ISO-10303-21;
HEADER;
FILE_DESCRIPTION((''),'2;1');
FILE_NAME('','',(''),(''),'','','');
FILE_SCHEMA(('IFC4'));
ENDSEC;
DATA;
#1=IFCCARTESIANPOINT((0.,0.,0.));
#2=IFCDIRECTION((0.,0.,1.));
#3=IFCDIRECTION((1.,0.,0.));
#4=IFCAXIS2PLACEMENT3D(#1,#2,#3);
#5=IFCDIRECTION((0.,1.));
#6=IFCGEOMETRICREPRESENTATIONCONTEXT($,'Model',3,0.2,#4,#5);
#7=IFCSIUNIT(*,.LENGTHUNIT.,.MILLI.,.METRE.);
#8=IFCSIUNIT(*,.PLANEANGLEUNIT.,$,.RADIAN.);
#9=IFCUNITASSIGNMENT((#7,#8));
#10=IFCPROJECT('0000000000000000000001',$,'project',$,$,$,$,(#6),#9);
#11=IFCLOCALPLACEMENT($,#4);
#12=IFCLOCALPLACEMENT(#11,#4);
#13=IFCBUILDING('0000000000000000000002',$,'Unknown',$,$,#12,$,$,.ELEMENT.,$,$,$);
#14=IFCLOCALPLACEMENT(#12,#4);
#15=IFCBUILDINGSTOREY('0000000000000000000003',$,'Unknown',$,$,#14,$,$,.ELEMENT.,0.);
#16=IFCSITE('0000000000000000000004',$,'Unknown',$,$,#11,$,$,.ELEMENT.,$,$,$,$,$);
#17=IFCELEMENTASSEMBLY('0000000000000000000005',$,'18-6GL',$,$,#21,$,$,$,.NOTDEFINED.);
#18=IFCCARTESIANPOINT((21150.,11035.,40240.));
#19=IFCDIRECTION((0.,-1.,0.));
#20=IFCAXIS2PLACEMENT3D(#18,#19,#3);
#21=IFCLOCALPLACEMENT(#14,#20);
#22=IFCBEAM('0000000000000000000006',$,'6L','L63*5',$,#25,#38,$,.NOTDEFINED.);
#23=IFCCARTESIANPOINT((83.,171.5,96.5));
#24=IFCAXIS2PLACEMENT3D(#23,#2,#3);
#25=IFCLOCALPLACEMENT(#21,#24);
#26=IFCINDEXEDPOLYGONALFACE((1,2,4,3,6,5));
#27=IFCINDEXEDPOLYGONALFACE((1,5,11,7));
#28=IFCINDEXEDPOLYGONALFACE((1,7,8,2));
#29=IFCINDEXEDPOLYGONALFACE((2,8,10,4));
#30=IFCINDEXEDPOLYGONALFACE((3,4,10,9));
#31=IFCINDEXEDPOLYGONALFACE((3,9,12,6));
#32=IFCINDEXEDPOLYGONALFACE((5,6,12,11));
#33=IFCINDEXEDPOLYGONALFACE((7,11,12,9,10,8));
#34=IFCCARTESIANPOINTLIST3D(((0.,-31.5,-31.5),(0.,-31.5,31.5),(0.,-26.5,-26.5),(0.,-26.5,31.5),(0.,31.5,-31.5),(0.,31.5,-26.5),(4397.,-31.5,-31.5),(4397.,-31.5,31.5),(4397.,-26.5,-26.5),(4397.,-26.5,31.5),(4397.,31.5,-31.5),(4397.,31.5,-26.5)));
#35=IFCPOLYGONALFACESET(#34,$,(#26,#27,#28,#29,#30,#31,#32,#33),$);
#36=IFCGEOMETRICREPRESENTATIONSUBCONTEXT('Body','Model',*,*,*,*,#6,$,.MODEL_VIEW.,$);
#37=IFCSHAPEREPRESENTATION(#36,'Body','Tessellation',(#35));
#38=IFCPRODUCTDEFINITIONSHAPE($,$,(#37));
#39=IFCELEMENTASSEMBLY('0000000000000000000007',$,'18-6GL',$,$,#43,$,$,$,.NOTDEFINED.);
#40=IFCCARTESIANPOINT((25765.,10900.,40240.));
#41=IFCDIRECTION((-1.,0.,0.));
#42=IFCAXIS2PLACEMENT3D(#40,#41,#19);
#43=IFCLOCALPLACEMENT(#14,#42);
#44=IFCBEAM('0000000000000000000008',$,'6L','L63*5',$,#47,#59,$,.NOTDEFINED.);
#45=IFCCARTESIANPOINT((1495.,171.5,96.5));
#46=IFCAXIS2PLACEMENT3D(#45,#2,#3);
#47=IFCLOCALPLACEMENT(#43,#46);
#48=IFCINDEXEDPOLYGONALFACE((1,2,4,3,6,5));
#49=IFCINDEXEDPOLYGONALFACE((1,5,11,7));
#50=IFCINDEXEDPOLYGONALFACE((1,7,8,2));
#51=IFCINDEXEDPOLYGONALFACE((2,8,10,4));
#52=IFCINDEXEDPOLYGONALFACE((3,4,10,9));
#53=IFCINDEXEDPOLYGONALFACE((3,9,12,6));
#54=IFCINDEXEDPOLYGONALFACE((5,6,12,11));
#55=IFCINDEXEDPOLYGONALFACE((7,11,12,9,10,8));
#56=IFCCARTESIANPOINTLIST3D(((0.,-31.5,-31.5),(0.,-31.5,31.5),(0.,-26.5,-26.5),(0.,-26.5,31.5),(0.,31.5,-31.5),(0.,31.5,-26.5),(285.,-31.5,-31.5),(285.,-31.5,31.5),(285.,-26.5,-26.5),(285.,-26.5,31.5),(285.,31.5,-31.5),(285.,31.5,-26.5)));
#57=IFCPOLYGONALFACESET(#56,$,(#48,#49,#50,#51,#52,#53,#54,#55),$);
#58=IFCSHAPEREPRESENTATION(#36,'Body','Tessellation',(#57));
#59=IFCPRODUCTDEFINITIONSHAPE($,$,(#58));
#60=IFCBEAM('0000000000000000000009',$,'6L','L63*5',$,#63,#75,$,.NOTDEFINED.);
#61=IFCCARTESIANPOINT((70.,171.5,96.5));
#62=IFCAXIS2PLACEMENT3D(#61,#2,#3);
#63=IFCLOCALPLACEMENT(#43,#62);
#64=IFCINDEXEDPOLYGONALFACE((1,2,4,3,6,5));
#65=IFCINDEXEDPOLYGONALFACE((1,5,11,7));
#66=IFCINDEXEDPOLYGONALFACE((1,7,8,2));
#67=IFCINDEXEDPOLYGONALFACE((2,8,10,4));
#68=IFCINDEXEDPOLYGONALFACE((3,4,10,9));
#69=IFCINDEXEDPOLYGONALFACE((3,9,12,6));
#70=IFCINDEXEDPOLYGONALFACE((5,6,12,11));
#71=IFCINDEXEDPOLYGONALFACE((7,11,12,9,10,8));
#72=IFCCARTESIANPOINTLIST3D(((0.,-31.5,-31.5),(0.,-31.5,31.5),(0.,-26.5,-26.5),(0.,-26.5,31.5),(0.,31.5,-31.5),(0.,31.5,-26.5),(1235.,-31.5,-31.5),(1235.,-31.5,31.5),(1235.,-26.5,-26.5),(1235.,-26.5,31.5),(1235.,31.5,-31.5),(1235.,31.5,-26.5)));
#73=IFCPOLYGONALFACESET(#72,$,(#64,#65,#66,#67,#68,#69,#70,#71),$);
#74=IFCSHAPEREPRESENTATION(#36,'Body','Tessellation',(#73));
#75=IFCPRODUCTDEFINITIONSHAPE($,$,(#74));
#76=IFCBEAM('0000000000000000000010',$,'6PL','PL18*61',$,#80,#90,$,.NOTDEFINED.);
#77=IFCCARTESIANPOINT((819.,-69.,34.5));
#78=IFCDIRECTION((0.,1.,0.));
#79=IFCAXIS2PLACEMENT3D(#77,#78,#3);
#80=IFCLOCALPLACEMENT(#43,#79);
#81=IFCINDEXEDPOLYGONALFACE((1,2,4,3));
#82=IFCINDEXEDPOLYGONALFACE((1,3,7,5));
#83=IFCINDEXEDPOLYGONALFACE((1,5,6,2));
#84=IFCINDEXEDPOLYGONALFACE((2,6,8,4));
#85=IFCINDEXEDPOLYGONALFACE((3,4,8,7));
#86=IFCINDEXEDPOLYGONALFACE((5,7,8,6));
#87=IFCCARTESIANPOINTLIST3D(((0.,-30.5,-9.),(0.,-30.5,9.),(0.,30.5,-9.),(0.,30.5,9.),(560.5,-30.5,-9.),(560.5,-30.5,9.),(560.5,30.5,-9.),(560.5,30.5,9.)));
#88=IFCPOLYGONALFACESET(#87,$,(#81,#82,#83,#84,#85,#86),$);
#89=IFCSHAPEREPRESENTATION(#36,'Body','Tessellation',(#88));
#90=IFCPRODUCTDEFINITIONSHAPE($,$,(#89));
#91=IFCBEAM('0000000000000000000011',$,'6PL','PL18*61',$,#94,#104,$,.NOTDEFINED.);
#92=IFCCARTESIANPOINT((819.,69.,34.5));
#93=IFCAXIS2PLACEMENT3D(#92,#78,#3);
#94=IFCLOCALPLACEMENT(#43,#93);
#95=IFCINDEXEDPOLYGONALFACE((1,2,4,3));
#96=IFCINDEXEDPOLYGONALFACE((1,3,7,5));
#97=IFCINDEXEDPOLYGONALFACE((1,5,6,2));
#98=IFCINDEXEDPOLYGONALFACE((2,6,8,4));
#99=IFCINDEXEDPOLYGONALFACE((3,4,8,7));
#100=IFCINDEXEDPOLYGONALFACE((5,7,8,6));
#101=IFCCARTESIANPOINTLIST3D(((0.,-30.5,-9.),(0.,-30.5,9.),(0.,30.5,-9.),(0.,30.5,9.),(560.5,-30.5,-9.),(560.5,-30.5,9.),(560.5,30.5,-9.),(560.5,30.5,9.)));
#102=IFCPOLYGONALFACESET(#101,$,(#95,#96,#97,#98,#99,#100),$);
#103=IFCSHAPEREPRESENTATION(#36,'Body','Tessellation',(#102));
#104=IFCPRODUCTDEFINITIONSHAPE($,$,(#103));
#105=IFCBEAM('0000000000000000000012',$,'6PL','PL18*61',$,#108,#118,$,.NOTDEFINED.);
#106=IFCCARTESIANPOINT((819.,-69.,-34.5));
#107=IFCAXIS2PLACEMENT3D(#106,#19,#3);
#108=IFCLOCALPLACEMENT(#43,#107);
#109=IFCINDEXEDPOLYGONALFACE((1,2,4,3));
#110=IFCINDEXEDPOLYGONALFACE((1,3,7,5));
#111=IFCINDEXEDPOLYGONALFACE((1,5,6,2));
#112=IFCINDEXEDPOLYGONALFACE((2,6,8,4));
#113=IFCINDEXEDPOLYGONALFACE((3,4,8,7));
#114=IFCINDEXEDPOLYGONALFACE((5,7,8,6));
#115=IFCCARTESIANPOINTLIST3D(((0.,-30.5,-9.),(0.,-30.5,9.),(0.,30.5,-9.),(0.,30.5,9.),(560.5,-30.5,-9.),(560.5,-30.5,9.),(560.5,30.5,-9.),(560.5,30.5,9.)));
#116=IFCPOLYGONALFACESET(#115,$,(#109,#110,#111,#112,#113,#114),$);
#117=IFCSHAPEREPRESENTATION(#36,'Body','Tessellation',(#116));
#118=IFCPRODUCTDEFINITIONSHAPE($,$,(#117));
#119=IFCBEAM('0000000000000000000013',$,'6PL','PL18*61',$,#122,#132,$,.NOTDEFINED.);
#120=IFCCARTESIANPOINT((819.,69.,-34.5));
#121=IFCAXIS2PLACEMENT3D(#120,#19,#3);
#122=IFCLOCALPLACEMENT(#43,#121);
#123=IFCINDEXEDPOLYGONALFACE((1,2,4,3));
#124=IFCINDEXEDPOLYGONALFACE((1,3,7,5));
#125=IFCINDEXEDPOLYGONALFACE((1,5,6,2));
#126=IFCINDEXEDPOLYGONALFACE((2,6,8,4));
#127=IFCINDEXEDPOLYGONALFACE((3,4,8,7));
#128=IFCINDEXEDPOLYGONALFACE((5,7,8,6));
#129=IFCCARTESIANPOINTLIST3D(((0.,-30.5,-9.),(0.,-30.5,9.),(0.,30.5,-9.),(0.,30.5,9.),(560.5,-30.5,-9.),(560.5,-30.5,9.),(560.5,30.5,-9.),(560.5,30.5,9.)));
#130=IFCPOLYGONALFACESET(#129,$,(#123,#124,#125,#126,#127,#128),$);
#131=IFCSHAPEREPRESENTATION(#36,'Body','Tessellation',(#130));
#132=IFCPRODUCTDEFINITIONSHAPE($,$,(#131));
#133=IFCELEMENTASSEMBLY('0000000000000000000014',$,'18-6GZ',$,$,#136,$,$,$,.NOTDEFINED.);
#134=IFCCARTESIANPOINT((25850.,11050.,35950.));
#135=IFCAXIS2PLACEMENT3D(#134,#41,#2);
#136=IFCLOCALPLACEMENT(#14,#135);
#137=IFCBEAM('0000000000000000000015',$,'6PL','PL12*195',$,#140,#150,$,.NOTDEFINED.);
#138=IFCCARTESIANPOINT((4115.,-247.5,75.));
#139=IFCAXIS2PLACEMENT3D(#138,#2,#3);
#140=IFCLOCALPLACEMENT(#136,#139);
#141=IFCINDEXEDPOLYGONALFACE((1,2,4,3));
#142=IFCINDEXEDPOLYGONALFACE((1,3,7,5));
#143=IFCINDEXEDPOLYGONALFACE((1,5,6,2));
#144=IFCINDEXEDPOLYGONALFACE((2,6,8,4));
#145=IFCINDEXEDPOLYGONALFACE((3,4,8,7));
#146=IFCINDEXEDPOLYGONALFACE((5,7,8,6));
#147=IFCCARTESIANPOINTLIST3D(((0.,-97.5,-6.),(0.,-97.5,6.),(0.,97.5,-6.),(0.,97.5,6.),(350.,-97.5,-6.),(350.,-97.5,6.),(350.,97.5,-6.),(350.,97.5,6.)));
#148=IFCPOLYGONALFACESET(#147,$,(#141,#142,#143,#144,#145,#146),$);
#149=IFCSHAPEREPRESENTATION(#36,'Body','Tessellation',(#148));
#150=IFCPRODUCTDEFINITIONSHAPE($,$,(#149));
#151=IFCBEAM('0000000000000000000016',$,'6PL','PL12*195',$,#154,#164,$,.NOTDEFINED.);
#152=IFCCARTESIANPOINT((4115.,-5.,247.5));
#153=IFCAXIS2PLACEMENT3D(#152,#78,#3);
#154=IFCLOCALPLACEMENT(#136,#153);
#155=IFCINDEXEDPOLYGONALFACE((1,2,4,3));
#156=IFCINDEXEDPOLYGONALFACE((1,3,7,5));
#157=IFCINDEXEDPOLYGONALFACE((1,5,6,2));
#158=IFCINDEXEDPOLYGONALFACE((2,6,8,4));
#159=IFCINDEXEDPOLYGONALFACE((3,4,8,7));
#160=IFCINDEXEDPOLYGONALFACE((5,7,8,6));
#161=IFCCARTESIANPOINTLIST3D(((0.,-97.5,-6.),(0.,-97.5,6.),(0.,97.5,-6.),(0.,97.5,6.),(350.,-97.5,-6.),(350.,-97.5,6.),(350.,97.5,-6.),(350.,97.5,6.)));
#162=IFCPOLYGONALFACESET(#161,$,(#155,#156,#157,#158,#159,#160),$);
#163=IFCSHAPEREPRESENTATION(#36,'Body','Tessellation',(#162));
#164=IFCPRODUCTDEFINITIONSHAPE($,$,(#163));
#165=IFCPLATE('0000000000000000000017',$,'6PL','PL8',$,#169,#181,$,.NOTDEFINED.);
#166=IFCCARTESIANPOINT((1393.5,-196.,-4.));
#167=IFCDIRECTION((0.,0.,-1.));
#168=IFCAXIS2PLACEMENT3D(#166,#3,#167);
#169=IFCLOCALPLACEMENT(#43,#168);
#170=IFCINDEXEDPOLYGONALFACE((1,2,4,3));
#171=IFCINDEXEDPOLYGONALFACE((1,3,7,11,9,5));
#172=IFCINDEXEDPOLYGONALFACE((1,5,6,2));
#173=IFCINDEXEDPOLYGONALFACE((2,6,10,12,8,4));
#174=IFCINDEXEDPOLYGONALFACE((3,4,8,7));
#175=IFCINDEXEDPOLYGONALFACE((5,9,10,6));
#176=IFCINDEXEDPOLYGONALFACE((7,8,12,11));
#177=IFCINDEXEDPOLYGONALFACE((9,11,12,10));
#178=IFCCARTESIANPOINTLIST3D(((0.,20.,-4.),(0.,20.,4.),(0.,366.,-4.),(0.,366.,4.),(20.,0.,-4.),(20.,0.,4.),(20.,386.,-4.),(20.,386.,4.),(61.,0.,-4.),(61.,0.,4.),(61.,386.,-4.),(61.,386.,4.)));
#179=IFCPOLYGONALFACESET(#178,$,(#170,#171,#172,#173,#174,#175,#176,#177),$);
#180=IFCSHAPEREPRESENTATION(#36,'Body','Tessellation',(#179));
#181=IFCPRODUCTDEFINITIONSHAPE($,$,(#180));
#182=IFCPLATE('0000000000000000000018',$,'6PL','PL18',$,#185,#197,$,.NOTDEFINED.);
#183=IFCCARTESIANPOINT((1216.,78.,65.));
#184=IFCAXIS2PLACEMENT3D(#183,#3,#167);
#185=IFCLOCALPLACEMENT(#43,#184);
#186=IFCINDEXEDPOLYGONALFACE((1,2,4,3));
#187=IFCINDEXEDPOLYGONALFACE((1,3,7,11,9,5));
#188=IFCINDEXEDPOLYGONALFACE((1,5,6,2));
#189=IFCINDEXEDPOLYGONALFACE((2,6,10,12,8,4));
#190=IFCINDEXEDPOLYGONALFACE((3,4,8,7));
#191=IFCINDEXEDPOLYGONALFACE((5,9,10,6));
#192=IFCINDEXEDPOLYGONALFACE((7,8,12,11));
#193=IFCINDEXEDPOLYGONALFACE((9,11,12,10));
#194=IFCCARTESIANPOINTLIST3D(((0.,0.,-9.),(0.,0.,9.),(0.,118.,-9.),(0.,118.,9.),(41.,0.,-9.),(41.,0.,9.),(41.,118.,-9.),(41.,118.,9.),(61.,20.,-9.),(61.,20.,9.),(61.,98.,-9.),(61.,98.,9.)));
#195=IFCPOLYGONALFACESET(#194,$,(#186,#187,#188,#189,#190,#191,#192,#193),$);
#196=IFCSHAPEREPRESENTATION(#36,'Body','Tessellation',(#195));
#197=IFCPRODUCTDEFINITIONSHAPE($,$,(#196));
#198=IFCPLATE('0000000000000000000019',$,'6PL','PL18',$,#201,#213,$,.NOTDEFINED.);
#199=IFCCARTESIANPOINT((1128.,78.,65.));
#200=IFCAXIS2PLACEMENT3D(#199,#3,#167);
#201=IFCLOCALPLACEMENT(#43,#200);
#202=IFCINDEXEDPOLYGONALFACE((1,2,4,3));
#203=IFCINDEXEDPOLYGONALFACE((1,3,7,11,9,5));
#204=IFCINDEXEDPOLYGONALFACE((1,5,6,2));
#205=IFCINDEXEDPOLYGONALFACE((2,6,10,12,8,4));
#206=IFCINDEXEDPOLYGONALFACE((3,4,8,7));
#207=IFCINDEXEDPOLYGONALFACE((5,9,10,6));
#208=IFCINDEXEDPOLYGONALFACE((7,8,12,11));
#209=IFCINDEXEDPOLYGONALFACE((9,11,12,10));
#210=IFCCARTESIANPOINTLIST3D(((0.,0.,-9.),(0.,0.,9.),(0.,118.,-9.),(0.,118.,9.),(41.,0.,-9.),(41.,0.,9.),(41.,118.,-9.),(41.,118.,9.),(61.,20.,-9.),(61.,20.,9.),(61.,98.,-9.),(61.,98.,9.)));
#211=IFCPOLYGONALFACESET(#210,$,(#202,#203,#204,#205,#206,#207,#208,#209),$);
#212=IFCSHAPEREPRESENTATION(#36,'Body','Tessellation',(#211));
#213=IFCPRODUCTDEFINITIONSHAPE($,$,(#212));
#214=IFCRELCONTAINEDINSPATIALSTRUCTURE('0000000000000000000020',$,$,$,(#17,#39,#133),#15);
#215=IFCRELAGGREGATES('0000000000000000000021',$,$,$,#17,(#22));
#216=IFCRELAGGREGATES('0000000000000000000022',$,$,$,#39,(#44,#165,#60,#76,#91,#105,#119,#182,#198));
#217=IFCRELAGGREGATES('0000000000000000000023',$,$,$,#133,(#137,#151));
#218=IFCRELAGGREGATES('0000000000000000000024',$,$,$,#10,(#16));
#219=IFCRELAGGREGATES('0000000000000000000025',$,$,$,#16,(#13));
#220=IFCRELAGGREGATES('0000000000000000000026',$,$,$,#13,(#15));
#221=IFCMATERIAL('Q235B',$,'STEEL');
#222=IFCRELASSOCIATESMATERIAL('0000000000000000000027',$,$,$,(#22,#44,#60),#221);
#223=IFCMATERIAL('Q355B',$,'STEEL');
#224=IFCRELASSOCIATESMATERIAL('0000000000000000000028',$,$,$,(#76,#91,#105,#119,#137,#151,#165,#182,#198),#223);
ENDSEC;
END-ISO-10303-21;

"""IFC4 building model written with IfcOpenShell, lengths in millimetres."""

from ifc_helpers import new_model, si_unit, direction, frame, origin_with_axes, place, context, subcontext, project, spatial, line, indexed_curve, outline, extrude, material, element, aggregate, save


model = new_model("IFC4")

# Units and contexts
model_context = context("Model", 3, precision=0.2, world=origin_with_axes(), true_north=direction((0.0, 1.0)))
body_context = subcontext(model_context, "Body", "Model", "MODEL_VIEW")
ifc_project = project(units=[si_unit("LENGTHUNIT", "METRE", prefix="MILLI"), si_unit("PLANEANGLEUNIT", "RADIAN")], contexts=[model_context])

# Site, building, storey
site_placement = place(None, origin_with_axes())
site = spatial("IfcSite", under=ifc_project, at=site_placement, Name="Unknown", CompositionType="ELEMENT")
building_placement = place(site_placement, origin_with_axes())
building = spatial("IfcBuilding", under=site, at=building_placement, Name="Unknown", CompositionType="ELEMENT")
storey_placement = place(building_placement, origin_with_axes())
storey = spatial("IfcBuildingStorey", under=building, at=storey_placement, Name="Unknown", CompositionType="ELEMENT", Elevation=0.0)

# Element assembly, beam
assembly_1_placement = place(storey_placement, frame((21150.0, 11035.0, 40240.0), z_axis=(0.0, -1.0, 0.0), x_axis=(1.0, 0.0, 0.0)))
assembly_1 = element("IfcElementAssembly", 1, at=assembly_1_placement, inside=storey, Name="18-6GL", PredefinedType="NOTDEFINED")
ifc_material_1 = material(Name="Q235B", Category="STEEL")
beam_1_placement = place(assembly_1_placement, frame((83.0, 171.5, 96.5), z_axis=(0.0, 0.0, 1.0), x_axis=(1.0, 0.0, 0.0)))
beam_1 = element("IfcBeam", 2, at=beam_1_placement, material=ifc_material_1, Name="6L", Description="L63*5", PredefinedType="NOTDEFINED", context=body_context, shape_type="SolidModel", body=[
    extrude(outline(indexed_curve([(-31.5, -31.5), (31.5, -31.5), (31.5, -26.5), (-26.5, -26.5), (-26.5, 31.5), (-31.5, 31.5)], segments=[line(1, 2, 3, 4, 5, 6, 1)])), frame((0.0, 0.0, 0.0), z_axis=(-1.0, 0.0, 0.0), x_axis=(0.0, 0.0, 1.0)), (0.0, 0.0, -1.0), 4397.0),
])

# Element assembly, beams
assembly_2_placement = place(storey_placement, frame((25765.0, 10900.0, 40240.0), z_axis=(-1.0, 0.0, 0.0), x_axis=(0.0, -1.0, 0.0)))
assembly_2 = element("IfcElementAssembly", 3, at=assembly_2_placement, inside=storey, Name="18-6GL", PredefinedType="NOTDEFINED")
beam_2_placement = place(assembly_2_placement, frame((1495.0, 171.5, 96.5), z_axis=(0.0, 0.0, 1.0), x_axis=(1.0, 0.0, 0.0)))
beam_2 = element("IfcBeam", 4, at=beam_2_placement, material=ifc_material_1, Name="6L", Description="L63*5", PredefinedType="NOTDEFINED", context=body_context, shape_type="SolidModel", body=[
    extrude(outline(indexed_curve([(-31.5, -31.5), (31.5, -31.5), (31.5, -26.5), (-26.5, -26.5), (-26.5, 31.5), (-31.5, 31.5)], segments=[line(1, 2, 3, 4, 5, 6, 1)])), frame((0.0, 0.0, 0.0), z_axis=(-1.0, 0.0, 0.0), x_axis=(0.0, 0.0, 1.0)), (0.0, 0.0, -1.0), 285.0),
])
beam_3_placement = place(assembly_2_placement, frame((70.0, 171.5, 96.5), z_axis=(0.0, 0.0, 1.0), x_axis=(1.0, 0.0, 0.0)))
beam_3 = element("IfcBeam", 5, at=beam_3_placement, material=ifc_material_1, Name="6L", Description="L63*5", PredefinedType="NOTDEFINED", context=body_context, shape_type="SolidModel", body=[
    extrude(outline(indexed_curve([(-31.5, -31.5), (31.5, -31.5), (31.5, -26.5), (-26.5, -26.5), (-26.5, 31.5), (-31.5, 31.5)], segments=[line(1, 2, 3, 4, 5, 6, 1)])), frame((0.0, 0.0, 0.0), z_axis=(-1.0, 0.0, 0.0), x_axis=(0.0, 0.0, 1.0)), (0.0, 0.0, -1.0), 1235.0),
])
ifc_material_2 = material(Name="Q355B", Category="STEEL")
beam_4_placement = place(assembly_2_placement, frame((819.0, -69.0, 34.5), z_axis=(0.0, 1.0, 0.0), x_axis=(1.0, 0.0, 0.0)))
beam_4 = element("IfcBeam", 6, at=beam_4_placement, material=ifc_material_2, Name="6PL", Description="PL18*61", PredefinedType="NOTDEFINED", context=body_context, shape_type="SolidModel", body=[
    extrude(outline(indexed_curve([(-9.0, -30.5), (9.0, -30.5), (9.0, 30.5), (-9.0, 30.5)], segments=[line(1, 2, 3, 4, 1)])), frame((0.0, 0.0, 0.0), z_axis=(-1.0, 0.0, 0.0), x_axis=(0.0, 0.0, 1.0)), (0.0, 0.0, -1.0), 560.5),
])
beam_5_placement = place(assembly_2_placement, frame((819.0, 69.0, 34.5), z_axis=(0.0, 1.0, 0.0), x_axis=(1.0, 0.0, 0.0)))
beam_5 = element("IfcBeam", 7, at=beam_5_placement, material=ifc_material_2, Name="6PL", Description="PL18*61", PredefinedType="NOTDEFINED", context=body_context, shape_type="SolidModel", body=[
    extrude(outline(indexed_curve([(-9.0, -30.5), (9.0, -30.5), (9.0, 30.5), (-9.0, 30.5)], segments=[line(1, 2, 3, 4, 1)])), frame((0.0, 0.0, 0.0), z_axis=(-1.0, 0.0, 0.0), x_axis=(0.0, 0.0, 1.0)), (0.0, 0.0, -1.0), 560.5),
])
beam_6_placement = place(assembly_2_placement, frame((819.0, -69.0, -34.5), z_axis=(0.0, -1.0, 0.0), x_axis=(1.0, 0.0, 0.0)))
beam_6 = element("IfcBeam", 8, at=beam_6_placement, material=ifc_material_2, Name="6PL", Description="PL18*61", PredefinedType="NOTDEFINED", context=body_context, shape_type="SolidModel", body=[
    extrude(outline(indexed_curve([(-9.0, -30.5), (9.0, -30.5), (9.0, 30.5), (-9.0, 30.5)], segments=[line(1, 2, 3, 4, 1)])), frame((0.0, 0.0, 0.0), z_axis=(-1.0, 0.0, 0.0), x_axis=(0.0, 0.0, 1.0)), (0.0, 0.0, -1.0), 560.5),
])
beam_7_placement = place(assembly_2_placement, frame((819.0, 69.0, -34.5), z_axis=(0.0, -1.0, 0.0), x_axis=(1.0, 0.0, 0.0)))
beam_7 = element("IfcBeam", 9, at=beam_7_placement, material=ifc_material_2, Name="6PL", Description="PL18*61", PredefinedType="NOTDEFINED", context=body_context, shape_type="SolidModel", body=[
    extrude(outline(indexed_curve([(-9.0, -30.5), (9.0, -30.5), (9.0, 30.5), (-9.0, 30.5)], segments=[line(1, 2, 3, 4, 1)])), frame((0.0, 0.0, 0.0), z_axis=(-1.0, 0.0, 0.0), x_axis=(0.0, 0.0, 1.0)), (0.0, 0.0, -1.0), 560.5),
])

# Element assembly, beams
assembly_3_placement = place(storey_placement, frame((25850.0, 11050.0, 35950.0), z_axis=(-1.0, 0.0, 0.0), x_axis=(0.0, 0.0, 1.0)))
assembly_3 = element("IfcElementAssembly", 10, at=assembly_3_placement, inside=storey, Name="18-6GZ", PredefinedType="NOTDEFINED")
beam_8_placement = place(assembly_3_placement, frame((4115.0, -247.5, 75.0), z_axis=(0.0, 0.0, 1.0), x_axis=(1.0, 0.0, 0.0)))
beam_8 = element("IfcBeam", 11, at=beam_8_placement, material=ifc_material_2, Name="6PL", Description="PL12*195", PredefinedType="NOTDEFINED", context=body_context, shape_type="SolidModel", body=[
    extrude(outline(indexed_curve([(-6.0, -97.5), (6.0, -97.5), (6.0, 97.5), (-6.0, 97.5)], segments=[line(1, 2, 3, 4, 1)])), frame((0.0, 0.0, 0.0), z_axis=(-1.0, 0.0, 0.0), x_axis=(0.0, 0.0, 1.0)), (0.0, 0.0, -1.0), 350.0),
])
beam_9_placement = place(assembly_3_placement, frame((4115.0, -5.0, 247.5), z_axis=(0.0, 1.0, 0.0), x_axis=(1.0, 0.0, 0.0)))
beam_9 = element("IfcBeam", 12, at=beam_9_placement, material=ifc_material_2, Name="6PL", Description="PL12*195", PredefinedType="NOTDEFINED", context=body_context, shape_type="SolidModel", body=[
    extrude(outline(indexed_curve([(-6.0, -97.5), (6.0, -97.5), (6.0, 97.5), (-6.0, 97.5)], segments=[line(1, 2, 3, 4, 1)])), frame((0.0, 0.0, 0.0), z_axis=(-1.0, 0.0, 0.0), x_axis=(0.0, 0.0, 1.0)), (0.0, 0.0, -1.0), 350.0),
])

# Plates
aggregate(assembly_1, [beam_1])
plate_1_placement = place(assembly_2_placement, frame((1393.5, -196.0, -4.0), z_axis=(1.0, 0.0, 0.0), x_axis=(0.0, 0.0, -1.0)))
plate_1 = element("IfcPlate", 13, at=plate_1_placement, material=ifc_material_2, Name="6PL", Description="PL8", PredefinedType="NOTDEFINED", context=body_context, shape_type="SolidModel", body=[
    extrude(outline(indexed_curve([(0.0, 20.0), (20.0, 0.0), (61.0, 0.0), (61.0, 386.0), (20.0, 386.0), (0.0, 366.0)], segments=[line(1, 2, 3, 4, 5, 6, 1)])), frame((0.0, 0.0, 4.0), z_axis=(0.0, 0.0, 1.0), x_axis=(1.0, 0.0, 0.0)), (0.0, 0.0, -1.0), 8.0),
])
plate_2_placement = place(assembly_2_placement, frame((1216.0, 78.0, 65.0), z_axis=(1.0, 0.0, 0.0), x_axis=(0.0, 0.0, -1.0)))
plate_2 = element("IfcPlate", 14, at=plate_2_placement, material=ifc_material_2, Name="6PL", Description="PL18", PredefinedType="NOTDEFINED", context=body_context, shape_type="SolidModel", body=[
    extrude(outline(indexed_curve([(0.0, 0.0), (41.0, 0.0), (61.0, 20.0), (61.0, 98.0), (41.0, 118.0), (0.0, 118.0)], segments=[line(1, 2, 3, 4, 5, 6, 1)])), frame((0.0, 0.0, 9.0), z_axis=(0.0, 0.0, 1.0), x_axis=(1.0, 0.0, 0.0)), (0.0, 0.0, -1.0), 18.0),
])
plate_3_placement = place(assembly_2_placement, frame((1128.0, 78.0, 65.0), z_axis=(1.0, 0.0, 0.0), x_axis=(0.0, 0.0, -1.0)))
plate_3 = element("IfcPlate", 15, at=plate_3_placement, material=ifc_material_2, Name="6PL", Description="PL18", PredefinedType="NOTDEFINED", context=body_context, shape_type="SolidModel", body=[
    extrude(outline(indexed_curve([(0.0, 0.0), (41.0, 0.0), (61.0, 20.0), (61.0, 98.0), (41.0, 118.0), (0.0, 118.0)], segments=[line(1, 2, 3, 4, 5, 6, 1)])), frame((0.0, 0.0, 9.0), z_axis=(0.0, 0.0, 1.0), x_axis=(1.0, 0.0, 0.0)), (0.0, 0.0, -1.0), 18.0),
])

aggregate(assembly_2, [beam_2, plate_1, beam_3, beam_4, beam_5, beam_6, beam_7, plate_2, plate_3])
aggregate(assembly_3, [beam_8, beam_9])

save(model, "model.ifc")
